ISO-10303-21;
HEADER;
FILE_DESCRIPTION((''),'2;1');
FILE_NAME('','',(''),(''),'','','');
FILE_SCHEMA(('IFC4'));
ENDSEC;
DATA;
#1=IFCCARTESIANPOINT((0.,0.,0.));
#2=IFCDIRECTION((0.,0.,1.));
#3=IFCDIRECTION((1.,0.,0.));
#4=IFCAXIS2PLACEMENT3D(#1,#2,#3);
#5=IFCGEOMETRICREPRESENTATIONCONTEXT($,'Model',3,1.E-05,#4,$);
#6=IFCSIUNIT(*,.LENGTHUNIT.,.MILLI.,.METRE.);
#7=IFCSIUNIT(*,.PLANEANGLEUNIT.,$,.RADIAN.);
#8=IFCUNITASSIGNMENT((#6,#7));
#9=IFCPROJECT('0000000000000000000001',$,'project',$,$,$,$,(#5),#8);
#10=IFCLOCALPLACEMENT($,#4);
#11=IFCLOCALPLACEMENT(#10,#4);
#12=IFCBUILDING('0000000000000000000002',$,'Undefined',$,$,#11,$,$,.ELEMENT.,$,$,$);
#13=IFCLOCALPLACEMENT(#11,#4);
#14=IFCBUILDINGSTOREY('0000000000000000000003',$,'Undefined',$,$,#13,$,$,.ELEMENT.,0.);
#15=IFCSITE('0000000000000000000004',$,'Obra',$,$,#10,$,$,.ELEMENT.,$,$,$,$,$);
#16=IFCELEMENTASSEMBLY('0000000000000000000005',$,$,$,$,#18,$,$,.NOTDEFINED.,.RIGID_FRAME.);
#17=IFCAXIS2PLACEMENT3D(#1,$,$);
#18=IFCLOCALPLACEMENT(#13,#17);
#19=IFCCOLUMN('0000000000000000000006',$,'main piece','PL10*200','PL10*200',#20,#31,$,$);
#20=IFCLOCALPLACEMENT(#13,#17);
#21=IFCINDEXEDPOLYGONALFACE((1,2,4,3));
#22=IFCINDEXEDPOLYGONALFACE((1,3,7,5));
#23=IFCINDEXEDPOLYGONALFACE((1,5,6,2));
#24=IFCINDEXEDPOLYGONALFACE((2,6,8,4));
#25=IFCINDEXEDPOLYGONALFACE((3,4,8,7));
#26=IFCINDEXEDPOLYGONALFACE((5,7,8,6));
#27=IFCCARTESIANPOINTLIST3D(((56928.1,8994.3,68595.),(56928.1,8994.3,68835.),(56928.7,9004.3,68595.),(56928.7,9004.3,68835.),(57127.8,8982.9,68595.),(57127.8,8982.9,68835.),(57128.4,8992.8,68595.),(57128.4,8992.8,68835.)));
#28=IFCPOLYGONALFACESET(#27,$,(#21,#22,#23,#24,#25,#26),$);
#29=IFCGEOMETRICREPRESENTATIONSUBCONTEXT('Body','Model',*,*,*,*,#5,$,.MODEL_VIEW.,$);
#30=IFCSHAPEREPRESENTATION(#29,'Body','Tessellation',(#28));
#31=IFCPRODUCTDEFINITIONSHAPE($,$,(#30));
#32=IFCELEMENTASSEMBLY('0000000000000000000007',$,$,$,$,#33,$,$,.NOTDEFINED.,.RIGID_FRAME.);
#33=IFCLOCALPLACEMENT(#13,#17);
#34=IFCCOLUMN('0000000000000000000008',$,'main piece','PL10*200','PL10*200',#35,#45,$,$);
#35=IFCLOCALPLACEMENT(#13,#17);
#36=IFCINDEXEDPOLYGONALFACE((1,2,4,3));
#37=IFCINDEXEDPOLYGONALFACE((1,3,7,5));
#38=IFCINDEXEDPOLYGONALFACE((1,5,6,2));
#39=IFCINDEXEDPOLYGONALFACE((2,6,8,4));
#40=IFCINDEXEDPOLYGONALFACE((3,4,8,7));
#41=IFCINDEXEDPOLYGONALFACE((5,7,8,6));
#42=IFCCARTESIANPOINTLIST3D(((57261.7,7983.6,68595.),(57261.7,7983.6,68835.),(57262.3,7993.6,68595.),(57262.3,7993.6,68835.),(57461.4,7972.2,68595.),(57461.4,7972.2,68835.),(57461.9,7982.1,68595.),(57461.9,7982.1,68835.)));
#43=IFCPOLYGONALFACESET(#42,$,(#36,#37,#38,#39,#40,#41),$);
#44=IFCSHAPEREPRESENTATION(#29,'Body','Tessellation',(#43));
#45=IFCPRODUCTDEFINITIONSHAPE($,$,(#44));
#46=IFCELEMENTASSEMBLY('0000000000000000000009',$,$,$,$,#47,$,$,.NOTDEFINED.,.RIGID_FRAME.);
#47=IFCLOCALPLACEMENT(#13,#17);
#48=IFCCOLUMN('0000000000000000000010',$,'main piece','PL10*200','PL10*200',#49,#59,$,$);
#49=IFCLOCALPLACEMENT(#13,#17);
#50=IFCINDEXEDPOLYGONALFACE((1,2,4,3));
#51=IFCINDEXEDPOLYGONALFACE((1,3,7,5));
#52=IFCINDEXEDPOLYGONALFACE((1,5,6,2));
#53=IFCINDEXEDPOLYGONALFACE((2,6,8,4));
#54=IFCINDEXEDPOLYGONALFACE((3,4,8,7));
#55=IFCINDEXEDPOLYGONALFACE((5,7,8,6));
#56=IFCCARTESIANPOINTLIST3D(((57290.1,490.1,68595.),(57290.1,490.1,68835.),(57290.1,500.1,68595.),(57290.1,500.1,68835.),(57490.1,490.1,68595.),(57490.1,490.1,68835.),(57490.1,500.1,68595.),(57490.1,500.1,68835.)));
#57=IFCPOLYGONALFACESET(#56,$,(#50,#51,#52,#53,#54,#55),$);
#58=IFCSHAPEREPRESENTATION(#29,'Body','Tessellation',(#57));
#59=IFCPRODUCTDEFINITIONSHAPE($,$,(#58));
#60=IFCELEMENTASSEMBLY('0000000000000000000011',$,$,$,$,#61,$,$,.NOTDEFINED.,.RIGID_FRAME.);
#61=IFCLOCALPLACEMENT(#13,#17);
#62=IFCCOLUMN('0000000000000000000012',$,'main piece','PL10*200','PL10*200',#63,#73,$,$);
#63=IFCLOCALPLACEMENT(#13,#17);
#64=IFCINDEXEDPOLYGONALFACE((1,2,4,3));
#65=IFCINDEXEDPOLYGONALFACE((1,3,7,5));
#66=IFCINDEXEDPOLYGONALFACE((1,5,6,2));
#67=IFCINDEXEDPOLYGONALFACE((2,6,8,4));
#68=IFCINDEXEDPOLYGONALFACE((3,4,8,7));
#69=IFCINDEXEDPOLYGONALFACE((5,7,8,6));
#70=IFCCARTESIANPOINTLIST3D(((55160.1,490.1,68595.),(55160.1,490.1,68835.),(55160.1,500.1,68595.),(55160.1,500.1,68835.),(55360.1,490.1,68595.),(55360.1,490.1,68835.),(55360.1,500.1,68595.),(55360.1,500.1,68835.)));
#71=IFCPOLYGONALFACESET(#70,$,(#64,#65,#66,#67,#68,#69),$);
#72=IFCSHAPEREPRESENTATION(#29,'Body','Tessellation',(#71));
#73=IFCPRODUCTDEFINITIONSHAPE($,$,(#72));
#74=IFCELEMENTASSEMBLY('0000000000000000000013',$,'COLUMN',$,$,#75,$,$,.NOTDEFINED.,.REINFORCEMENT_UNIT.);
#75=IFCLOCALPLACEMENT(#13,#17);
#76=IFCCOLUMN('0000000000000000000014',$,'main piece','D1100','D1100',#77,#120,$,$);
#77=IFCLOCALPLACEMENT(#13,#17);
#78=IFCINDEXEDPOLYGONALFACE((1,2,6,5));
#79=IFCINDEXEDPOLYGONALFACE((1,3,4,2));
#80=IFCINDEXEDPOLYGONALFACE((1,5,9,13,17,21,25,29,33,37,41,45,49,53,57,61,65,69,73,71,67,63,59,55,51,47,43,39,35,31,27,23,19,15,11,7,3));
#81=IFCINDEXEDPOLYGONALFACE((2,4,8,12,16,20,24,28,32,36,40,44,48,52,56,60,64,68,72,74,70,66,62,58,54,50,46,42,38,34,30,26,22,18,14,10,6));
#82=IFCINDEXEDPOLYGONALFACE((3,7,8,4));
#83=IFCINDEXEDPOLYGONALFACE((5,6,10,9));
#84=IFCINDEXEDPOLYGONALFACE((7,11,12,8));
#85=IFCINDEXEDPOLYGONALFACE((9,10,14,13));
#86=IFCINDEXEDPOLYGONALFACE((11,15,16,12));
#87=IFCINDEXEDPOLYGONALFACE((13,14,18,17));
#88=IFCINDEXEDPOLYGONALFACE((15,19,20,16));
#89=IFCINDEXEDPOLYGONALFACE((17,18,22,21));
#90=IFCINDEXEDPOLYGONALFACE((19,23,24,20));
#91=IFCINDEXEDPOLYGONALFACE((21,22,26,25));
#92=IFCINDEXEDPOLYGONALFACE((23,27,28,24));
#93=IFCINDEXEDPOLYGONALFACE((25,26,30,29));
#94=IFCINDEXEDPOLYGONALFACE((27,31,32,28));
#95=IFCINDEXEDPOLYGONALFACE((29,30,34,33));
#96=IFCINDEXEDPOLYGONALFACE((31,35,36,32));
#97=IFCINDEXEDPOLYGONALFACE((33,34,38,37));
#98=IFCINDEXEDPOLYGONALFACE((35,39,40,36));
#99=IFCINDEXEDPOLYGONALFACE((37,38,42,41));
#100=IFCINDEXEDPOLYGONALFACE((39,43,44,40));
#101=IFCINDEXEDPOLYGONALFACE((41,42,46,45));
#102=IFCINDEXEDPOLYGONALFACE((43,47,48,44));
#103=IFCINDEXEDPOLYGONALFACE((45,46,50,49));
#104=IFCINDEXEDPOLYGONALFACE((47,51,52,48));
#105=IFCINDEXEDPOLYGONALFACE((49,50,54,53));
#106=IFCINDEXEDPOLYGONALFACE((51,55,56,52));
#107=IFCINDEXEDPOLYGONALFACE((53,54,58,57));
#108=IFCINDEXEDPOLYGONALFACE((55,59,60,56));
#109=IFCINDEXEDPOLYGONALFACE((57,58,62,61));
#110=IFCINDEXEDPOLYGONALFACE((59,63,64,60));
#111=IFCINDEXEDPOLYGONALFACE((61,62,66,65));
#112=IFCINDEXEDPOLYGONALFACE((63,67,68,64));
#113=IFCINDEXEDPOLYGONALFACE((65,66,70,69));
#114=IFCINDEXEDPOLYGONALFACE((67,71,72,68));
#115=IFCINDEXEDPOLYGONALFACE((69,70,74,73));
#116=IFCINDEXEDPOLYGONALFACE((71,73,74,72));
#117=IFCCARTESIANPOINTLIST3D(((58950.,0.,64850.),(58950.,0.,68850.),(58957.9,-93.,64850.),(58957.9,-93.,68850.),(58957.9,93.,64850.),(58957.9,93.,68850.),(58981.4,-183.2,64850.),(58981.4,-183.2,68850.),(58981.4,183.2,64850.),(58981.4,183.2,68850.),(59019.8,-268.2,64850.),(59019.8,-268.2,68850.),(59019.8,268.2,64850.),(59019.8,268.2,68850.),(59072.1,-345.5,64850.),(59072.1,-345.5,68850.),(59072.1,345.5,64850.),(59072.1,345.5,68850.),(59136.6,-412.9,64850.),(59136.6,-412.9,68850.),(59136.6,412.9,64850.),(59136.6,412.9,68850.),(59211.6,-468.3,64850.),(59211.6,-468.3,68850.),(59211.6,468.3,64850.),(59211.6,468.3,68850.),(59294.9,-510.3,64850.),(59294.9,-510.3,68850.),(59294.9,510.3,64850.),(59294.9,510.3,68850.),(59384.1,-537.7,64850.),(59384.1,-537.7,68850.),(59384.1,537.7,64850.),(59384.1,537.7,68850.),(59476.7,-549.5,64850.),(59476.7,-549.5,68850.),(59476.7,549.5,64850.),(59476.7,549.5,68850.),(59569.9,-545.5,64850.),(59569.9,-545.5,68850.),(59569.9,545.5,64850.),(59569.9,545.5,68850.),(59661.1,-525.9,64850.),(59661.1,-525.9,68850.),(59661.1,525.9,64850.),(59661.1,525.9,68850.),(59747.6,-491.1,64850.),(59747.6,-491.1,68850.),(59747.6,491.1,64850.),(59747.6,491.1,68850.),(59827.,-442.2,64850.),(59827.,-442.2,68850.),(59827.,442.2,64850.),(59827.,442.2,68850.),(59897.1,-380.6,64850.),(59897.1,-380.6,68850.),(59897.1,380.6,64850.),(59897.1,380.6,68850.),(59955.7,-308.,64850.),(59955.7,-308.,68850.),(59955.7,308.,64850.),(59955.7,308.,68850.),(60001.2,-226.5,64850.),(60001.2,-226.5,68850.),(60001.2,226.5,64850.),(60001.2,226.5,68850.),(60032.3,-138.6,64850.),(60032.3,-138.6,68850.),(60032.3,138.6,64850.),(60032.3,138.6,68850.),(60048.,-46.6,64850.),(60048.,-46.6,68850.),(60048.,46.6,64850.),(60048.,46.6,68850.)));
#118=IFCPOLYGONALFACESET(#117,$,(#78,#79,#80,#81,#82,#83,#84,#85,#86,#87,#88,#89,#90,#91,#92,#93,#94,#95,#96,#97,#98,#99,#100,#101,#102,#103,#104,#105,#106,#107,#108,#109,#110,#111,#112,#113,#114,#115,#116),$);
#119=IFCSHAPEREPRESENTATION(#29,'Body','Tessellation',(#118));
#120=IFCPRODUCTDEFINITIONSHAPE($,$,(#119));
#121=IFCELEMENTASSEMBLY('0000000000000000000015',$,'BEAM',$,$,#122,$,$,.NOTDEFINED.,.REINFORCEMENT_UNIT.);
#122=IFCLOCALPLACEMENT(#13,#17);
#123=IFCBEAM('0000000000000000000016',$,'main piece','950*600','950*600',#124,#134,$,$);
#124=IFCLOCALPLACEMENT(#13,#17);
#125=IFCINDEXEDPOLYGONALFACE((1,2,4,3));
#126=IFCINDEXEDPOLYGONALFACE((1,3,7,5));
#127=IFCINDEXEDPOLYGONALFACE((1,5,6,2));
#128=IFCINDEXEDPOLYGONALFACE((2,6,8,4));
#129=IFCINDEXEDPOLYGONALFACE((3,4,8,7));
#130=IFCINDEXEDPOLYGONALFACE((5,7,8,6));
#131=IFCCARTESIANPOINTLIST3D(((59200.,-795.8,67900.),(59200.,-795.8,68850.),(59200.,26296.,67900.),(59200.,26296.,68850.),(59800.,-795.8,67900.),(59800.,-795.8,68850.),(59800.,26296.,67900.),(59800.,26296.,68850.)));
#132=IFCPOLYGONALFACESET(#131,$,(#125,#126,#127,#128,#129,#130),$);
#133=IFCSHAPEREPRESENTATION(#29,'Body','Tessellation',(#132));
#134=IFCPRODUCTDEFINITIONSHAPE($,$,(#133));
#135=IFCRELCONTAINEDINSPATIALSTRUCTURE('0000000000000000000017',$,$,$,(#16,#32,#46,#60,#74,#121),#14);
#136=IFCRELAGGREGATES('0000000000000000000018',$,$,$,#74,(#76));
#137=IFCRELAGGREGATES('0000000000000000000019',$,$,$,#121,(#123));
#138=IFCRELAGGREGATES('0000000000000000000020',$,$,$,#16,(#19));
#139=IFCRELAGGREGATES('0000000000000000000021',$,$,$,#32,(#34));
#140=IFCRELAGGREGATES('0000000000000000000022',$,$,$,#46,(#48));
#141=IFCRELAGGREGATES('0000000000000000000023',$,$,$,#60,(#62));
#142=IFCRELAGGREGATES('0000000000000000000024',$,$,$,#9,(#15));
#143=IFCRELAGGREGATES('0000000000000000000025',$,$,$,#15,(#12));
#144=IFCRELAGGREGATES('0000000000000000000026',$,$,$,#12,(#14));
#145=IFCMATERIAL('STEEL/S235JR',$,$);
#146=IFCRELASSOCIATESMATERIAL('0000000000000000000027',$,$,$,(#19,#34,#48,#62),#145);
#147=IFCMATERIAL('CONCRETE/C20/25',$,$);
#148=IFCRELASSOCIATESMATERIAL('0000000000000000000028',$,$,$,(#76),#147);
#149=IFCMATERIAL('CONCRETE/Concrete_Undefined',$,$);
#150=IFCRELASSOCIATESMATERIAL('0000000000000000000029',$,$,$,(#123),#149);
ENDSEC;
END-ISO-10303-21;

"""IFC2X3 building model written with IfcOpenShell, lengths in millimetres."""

from ifc_helpers import new_model, si_unit, frame, origin_with_axes, origin_2d_with_axis, place, context, subcontext, project, spatial, rectangle, circle, extrude, material, element, aggregate, save


model = new_model("IFC2X3")

# Units and contexts
model_context = context("Model", 3, precision=1e-05, world=origin_with_axes())
body_context = subcontext(model_context, "Body", "Model", "MODEL_VIEW")
ifc_project = project(units=[si_unit("LENGTHUNIT", "METRE", prefix="MILLI"), si_unit("PLANEANGLEUNIT", "RADIAN")], contexts=[model_context])

# Site, building, storey
site_placement = place(None, origin_with_axes())
site = spatial("IfcSite", under=ifc_project, at=site_placement, Name="Obra", CompositionType="ELEMENT")
building_placement = place(site_placement, origin_with_axes())
building = spatial("IfcBuilding", under=site, at=building_placement, Name="Undefined", CompositionType="ELEMENT")
storey_placement = place(building_placement, origin_with_axes())
storey = spatial("IfcBuildingStorey", under=building, at=storey_placement, Name="Undefined", CompositionType="ELEMENT", Elevation=0.0)

# Element assemblies, columns
assembly_1_placement = place(storey_placement, origin_with_axes())
assembly_1 = element("IfcElementAssembly", 1, at=assembly_1_placement, inside=storey, AssemblyPlace="NOTDEFINED", PredefinedType="RIGID_FRAME")
ifc_material_1 = material(Name="STEEL/S235JR")
column_1_placement = place(assembly_1_placement, frame((57028.3, 8993.6, 68595.0), z_axis=(0.0, 0.0, 1.0), x_axis=(0.998368, -0.05711, 0.0)))
column_1 = element("IfcColumn", 2, at=column_1_placement, material=ifc_material_1, Name="main piece", Description="PL10*200", ObjectType="PL10*200", context=body_context, shape_type="SweptSolid", body=[
    extrude(rectangle(XDim=10.0, YDim=200.0, at=origin_2d_with_axis()), frame((0.0, 0.0, 240.0), z_axis=(0.0, 0.0, -1.0), x_axis=(0.0, 1.0, 0.0)), (0.0, 0.0, 1.0), 240.0),
])
assembly_2_placement = place(storey_placement, origin_with_axes())
assembly_2 = element("IfcElementAssembly", 3, at=assembly_2_placement, inside=storey, AssemblyPlace="NOTDEFINED", PredefinedType="RIGID_FRAME")
column_2_placement = place(assembly_2_placement, frame((57361.8, 7982.9, 68595.0), z_axis=(0.0, 0.0, 1.0), x_axis=(-0.998368, 0.05711, 0.0)))
column_2 = element("IfcColumn", 4, at=column_2_placement, material=ifc_material_1, Name="main piece", Description="PL10*200", ObjectType="PL10*200", context=body_context, shape_type="SweptSolid", body=[
    extrude(rectangle(XDim=10.0, YDim=200.0, at=origin_2d_with_axis()), frame((0.0, 0.0, 240.0), z_axis=(0.0, 0.0, -1.0), x_axis=(0.0, 1.0, 0.0)), (0.0, 0.0, 1.0), 240.0),
])
assembly_3_placement = place(storey_placement, origin_with_axes())
assembly_3 = element("IfcElementAssembly", 5, at=assembly_3_placement, inside=storey, AssemblyPlace="NOTDEFINED", PredefinedType="RIGID_FRAME")
column_3_placement = place(assembly_3_placement, frame((57390.1, 495.1, 68595.0), z_axis=(0.0, 0.0, 1.0), x_axis=(1.0, 0.000001, 0.0)))
column_3 = element("IfcColumn", 6, at=column_3_placement, material=ifc_material_1, Name="main piece", Description="PL10*200", ObjectType="PL10*200", context=body_context, shape_type="SweptSolid", body=[
    extrude(rectangle(XDim=10.0, YDim=200.0, at=origin_2d_with_axis()), frame((0.0, 0.0, 240.0), z_axis=(0.0, 0.0, -1.0), x_axis=(0.0, 1.0, 0.0)), (0.0, 0.0, 1.0), 240.0),
])
assembly_4_placement = place(storey_placement, origin_with_axes())
assembly_4 = element("IfcElementAssembly", 7, at=assembly_4_placement, inside=storey, AssemblyPlace="NOTDEFINED", PredefinedType="RIGID_FRAME")
column_4_placement = place(assembly_4_placement, frame((55260.1, 495.1, 68595.0), z_axis=(0.0, 0.0, 1.0), x_axis=(1.0, 0.000001, 0.0)))
column_4 = element("IfcColumn", 8, at=column_4_placement, material=ifc_material_1, Name="main piece", Description="PL10*200", ObjectType="PL10*200", context=body_context, shape_type="SweptSolid", body=[
    extrude(rectangle(XDim=10.0, YDim=200.0, at=origin_2d_with_axis()), frame((0.0, 0.0, 240.0), z_axis=(0.0, 0.0, -1.0), x_axis=(0.0, 1.0, 0.0)), (0.0, 0.0, 1.0), 240.0),
])
assembly_5_placement = place(storey_placement, origin_with_axes())
assembly_5 = element("IfcElementAssembly", 9, at=assembly_5_placement, inside=storey, Name="COLUMN", AssemblyPlace="NOTDEFINED", PredefinedType="REINFORCEMENT_UNIT")
ifc_material_2 = material(Name="CONCRETE/C20/25")
column_5_placement = place(assembly_5_placement, frame((59500.0, 0.0, 64850.0), z_axis=(0.0, 0.0, 1.0), x_axis=(0.0, 1.0, 0.0)))
column_5 = element("IfcColumn", 10, at=column_5_placement, material=ifc_material_2, Name="main piece", Description="D1100", ObjectType="D1100", context=body_context, shape_type="SweptSolid", body=[
    extrude(circle(Radius=550.0, at=origin_2d_with_axis()), frame((0.0, 0.0, 4000.0), z_axis=(0.0, 0.0, -1.0), x_axis=(0.0, 1.0, 0.0)), (0.0, 0.0, 1.0), 4000.0),
])
aggregate(assembly_5, [column_5])

# Element assembly, beam
assembly_6_placement = place(storey_placement, origin_with_axes())
assembly_6 = element("IfcElementAssembly", 11, at=assembly_6_placement, inside=storey, Name="BEAM", AssemblyPlace="NOTDEFINED", PredefinedType="REINFORCEMENT_UNIT")
ifc_material_3 = material(Name="CONCRETE/Concrete_Undefined")
beam_1_placement = place(assembly_6_placement, frame((59500.0, -795.8, 68375.0), z_axis=(0.0, 0.0, 1.0), x_axis=(0.0, 1.0, 0.0)))
beam_1 = element("IfcBeam", 12, at=beam_1_placement, material=ifc_material_3, Name="main piece", Description="950*600", ObjectType="950*600", context=body_context, shape_type="SweptSolid", body=[
    extrude(rectangle(XDim=600.0, YDim=950.0, at=origin_2d_with_axis()), frame((27091.8, 0.0, 0.0), z_axis=(-1.0, 0.0, 0.0), x_axis=(0.0, -1.0, 0.0)), (0.0, 0.0, 1.0), 27091.8),
])
aggregate(assembly_6, [beam_1])

aggregate(assembly_1, [column_1])

aggregate(assembly_2, [column_2])
aggregate(assembly_3, [column_3])
aggregate(assembly_4, [column_4])

save(model, "model.ifc")
